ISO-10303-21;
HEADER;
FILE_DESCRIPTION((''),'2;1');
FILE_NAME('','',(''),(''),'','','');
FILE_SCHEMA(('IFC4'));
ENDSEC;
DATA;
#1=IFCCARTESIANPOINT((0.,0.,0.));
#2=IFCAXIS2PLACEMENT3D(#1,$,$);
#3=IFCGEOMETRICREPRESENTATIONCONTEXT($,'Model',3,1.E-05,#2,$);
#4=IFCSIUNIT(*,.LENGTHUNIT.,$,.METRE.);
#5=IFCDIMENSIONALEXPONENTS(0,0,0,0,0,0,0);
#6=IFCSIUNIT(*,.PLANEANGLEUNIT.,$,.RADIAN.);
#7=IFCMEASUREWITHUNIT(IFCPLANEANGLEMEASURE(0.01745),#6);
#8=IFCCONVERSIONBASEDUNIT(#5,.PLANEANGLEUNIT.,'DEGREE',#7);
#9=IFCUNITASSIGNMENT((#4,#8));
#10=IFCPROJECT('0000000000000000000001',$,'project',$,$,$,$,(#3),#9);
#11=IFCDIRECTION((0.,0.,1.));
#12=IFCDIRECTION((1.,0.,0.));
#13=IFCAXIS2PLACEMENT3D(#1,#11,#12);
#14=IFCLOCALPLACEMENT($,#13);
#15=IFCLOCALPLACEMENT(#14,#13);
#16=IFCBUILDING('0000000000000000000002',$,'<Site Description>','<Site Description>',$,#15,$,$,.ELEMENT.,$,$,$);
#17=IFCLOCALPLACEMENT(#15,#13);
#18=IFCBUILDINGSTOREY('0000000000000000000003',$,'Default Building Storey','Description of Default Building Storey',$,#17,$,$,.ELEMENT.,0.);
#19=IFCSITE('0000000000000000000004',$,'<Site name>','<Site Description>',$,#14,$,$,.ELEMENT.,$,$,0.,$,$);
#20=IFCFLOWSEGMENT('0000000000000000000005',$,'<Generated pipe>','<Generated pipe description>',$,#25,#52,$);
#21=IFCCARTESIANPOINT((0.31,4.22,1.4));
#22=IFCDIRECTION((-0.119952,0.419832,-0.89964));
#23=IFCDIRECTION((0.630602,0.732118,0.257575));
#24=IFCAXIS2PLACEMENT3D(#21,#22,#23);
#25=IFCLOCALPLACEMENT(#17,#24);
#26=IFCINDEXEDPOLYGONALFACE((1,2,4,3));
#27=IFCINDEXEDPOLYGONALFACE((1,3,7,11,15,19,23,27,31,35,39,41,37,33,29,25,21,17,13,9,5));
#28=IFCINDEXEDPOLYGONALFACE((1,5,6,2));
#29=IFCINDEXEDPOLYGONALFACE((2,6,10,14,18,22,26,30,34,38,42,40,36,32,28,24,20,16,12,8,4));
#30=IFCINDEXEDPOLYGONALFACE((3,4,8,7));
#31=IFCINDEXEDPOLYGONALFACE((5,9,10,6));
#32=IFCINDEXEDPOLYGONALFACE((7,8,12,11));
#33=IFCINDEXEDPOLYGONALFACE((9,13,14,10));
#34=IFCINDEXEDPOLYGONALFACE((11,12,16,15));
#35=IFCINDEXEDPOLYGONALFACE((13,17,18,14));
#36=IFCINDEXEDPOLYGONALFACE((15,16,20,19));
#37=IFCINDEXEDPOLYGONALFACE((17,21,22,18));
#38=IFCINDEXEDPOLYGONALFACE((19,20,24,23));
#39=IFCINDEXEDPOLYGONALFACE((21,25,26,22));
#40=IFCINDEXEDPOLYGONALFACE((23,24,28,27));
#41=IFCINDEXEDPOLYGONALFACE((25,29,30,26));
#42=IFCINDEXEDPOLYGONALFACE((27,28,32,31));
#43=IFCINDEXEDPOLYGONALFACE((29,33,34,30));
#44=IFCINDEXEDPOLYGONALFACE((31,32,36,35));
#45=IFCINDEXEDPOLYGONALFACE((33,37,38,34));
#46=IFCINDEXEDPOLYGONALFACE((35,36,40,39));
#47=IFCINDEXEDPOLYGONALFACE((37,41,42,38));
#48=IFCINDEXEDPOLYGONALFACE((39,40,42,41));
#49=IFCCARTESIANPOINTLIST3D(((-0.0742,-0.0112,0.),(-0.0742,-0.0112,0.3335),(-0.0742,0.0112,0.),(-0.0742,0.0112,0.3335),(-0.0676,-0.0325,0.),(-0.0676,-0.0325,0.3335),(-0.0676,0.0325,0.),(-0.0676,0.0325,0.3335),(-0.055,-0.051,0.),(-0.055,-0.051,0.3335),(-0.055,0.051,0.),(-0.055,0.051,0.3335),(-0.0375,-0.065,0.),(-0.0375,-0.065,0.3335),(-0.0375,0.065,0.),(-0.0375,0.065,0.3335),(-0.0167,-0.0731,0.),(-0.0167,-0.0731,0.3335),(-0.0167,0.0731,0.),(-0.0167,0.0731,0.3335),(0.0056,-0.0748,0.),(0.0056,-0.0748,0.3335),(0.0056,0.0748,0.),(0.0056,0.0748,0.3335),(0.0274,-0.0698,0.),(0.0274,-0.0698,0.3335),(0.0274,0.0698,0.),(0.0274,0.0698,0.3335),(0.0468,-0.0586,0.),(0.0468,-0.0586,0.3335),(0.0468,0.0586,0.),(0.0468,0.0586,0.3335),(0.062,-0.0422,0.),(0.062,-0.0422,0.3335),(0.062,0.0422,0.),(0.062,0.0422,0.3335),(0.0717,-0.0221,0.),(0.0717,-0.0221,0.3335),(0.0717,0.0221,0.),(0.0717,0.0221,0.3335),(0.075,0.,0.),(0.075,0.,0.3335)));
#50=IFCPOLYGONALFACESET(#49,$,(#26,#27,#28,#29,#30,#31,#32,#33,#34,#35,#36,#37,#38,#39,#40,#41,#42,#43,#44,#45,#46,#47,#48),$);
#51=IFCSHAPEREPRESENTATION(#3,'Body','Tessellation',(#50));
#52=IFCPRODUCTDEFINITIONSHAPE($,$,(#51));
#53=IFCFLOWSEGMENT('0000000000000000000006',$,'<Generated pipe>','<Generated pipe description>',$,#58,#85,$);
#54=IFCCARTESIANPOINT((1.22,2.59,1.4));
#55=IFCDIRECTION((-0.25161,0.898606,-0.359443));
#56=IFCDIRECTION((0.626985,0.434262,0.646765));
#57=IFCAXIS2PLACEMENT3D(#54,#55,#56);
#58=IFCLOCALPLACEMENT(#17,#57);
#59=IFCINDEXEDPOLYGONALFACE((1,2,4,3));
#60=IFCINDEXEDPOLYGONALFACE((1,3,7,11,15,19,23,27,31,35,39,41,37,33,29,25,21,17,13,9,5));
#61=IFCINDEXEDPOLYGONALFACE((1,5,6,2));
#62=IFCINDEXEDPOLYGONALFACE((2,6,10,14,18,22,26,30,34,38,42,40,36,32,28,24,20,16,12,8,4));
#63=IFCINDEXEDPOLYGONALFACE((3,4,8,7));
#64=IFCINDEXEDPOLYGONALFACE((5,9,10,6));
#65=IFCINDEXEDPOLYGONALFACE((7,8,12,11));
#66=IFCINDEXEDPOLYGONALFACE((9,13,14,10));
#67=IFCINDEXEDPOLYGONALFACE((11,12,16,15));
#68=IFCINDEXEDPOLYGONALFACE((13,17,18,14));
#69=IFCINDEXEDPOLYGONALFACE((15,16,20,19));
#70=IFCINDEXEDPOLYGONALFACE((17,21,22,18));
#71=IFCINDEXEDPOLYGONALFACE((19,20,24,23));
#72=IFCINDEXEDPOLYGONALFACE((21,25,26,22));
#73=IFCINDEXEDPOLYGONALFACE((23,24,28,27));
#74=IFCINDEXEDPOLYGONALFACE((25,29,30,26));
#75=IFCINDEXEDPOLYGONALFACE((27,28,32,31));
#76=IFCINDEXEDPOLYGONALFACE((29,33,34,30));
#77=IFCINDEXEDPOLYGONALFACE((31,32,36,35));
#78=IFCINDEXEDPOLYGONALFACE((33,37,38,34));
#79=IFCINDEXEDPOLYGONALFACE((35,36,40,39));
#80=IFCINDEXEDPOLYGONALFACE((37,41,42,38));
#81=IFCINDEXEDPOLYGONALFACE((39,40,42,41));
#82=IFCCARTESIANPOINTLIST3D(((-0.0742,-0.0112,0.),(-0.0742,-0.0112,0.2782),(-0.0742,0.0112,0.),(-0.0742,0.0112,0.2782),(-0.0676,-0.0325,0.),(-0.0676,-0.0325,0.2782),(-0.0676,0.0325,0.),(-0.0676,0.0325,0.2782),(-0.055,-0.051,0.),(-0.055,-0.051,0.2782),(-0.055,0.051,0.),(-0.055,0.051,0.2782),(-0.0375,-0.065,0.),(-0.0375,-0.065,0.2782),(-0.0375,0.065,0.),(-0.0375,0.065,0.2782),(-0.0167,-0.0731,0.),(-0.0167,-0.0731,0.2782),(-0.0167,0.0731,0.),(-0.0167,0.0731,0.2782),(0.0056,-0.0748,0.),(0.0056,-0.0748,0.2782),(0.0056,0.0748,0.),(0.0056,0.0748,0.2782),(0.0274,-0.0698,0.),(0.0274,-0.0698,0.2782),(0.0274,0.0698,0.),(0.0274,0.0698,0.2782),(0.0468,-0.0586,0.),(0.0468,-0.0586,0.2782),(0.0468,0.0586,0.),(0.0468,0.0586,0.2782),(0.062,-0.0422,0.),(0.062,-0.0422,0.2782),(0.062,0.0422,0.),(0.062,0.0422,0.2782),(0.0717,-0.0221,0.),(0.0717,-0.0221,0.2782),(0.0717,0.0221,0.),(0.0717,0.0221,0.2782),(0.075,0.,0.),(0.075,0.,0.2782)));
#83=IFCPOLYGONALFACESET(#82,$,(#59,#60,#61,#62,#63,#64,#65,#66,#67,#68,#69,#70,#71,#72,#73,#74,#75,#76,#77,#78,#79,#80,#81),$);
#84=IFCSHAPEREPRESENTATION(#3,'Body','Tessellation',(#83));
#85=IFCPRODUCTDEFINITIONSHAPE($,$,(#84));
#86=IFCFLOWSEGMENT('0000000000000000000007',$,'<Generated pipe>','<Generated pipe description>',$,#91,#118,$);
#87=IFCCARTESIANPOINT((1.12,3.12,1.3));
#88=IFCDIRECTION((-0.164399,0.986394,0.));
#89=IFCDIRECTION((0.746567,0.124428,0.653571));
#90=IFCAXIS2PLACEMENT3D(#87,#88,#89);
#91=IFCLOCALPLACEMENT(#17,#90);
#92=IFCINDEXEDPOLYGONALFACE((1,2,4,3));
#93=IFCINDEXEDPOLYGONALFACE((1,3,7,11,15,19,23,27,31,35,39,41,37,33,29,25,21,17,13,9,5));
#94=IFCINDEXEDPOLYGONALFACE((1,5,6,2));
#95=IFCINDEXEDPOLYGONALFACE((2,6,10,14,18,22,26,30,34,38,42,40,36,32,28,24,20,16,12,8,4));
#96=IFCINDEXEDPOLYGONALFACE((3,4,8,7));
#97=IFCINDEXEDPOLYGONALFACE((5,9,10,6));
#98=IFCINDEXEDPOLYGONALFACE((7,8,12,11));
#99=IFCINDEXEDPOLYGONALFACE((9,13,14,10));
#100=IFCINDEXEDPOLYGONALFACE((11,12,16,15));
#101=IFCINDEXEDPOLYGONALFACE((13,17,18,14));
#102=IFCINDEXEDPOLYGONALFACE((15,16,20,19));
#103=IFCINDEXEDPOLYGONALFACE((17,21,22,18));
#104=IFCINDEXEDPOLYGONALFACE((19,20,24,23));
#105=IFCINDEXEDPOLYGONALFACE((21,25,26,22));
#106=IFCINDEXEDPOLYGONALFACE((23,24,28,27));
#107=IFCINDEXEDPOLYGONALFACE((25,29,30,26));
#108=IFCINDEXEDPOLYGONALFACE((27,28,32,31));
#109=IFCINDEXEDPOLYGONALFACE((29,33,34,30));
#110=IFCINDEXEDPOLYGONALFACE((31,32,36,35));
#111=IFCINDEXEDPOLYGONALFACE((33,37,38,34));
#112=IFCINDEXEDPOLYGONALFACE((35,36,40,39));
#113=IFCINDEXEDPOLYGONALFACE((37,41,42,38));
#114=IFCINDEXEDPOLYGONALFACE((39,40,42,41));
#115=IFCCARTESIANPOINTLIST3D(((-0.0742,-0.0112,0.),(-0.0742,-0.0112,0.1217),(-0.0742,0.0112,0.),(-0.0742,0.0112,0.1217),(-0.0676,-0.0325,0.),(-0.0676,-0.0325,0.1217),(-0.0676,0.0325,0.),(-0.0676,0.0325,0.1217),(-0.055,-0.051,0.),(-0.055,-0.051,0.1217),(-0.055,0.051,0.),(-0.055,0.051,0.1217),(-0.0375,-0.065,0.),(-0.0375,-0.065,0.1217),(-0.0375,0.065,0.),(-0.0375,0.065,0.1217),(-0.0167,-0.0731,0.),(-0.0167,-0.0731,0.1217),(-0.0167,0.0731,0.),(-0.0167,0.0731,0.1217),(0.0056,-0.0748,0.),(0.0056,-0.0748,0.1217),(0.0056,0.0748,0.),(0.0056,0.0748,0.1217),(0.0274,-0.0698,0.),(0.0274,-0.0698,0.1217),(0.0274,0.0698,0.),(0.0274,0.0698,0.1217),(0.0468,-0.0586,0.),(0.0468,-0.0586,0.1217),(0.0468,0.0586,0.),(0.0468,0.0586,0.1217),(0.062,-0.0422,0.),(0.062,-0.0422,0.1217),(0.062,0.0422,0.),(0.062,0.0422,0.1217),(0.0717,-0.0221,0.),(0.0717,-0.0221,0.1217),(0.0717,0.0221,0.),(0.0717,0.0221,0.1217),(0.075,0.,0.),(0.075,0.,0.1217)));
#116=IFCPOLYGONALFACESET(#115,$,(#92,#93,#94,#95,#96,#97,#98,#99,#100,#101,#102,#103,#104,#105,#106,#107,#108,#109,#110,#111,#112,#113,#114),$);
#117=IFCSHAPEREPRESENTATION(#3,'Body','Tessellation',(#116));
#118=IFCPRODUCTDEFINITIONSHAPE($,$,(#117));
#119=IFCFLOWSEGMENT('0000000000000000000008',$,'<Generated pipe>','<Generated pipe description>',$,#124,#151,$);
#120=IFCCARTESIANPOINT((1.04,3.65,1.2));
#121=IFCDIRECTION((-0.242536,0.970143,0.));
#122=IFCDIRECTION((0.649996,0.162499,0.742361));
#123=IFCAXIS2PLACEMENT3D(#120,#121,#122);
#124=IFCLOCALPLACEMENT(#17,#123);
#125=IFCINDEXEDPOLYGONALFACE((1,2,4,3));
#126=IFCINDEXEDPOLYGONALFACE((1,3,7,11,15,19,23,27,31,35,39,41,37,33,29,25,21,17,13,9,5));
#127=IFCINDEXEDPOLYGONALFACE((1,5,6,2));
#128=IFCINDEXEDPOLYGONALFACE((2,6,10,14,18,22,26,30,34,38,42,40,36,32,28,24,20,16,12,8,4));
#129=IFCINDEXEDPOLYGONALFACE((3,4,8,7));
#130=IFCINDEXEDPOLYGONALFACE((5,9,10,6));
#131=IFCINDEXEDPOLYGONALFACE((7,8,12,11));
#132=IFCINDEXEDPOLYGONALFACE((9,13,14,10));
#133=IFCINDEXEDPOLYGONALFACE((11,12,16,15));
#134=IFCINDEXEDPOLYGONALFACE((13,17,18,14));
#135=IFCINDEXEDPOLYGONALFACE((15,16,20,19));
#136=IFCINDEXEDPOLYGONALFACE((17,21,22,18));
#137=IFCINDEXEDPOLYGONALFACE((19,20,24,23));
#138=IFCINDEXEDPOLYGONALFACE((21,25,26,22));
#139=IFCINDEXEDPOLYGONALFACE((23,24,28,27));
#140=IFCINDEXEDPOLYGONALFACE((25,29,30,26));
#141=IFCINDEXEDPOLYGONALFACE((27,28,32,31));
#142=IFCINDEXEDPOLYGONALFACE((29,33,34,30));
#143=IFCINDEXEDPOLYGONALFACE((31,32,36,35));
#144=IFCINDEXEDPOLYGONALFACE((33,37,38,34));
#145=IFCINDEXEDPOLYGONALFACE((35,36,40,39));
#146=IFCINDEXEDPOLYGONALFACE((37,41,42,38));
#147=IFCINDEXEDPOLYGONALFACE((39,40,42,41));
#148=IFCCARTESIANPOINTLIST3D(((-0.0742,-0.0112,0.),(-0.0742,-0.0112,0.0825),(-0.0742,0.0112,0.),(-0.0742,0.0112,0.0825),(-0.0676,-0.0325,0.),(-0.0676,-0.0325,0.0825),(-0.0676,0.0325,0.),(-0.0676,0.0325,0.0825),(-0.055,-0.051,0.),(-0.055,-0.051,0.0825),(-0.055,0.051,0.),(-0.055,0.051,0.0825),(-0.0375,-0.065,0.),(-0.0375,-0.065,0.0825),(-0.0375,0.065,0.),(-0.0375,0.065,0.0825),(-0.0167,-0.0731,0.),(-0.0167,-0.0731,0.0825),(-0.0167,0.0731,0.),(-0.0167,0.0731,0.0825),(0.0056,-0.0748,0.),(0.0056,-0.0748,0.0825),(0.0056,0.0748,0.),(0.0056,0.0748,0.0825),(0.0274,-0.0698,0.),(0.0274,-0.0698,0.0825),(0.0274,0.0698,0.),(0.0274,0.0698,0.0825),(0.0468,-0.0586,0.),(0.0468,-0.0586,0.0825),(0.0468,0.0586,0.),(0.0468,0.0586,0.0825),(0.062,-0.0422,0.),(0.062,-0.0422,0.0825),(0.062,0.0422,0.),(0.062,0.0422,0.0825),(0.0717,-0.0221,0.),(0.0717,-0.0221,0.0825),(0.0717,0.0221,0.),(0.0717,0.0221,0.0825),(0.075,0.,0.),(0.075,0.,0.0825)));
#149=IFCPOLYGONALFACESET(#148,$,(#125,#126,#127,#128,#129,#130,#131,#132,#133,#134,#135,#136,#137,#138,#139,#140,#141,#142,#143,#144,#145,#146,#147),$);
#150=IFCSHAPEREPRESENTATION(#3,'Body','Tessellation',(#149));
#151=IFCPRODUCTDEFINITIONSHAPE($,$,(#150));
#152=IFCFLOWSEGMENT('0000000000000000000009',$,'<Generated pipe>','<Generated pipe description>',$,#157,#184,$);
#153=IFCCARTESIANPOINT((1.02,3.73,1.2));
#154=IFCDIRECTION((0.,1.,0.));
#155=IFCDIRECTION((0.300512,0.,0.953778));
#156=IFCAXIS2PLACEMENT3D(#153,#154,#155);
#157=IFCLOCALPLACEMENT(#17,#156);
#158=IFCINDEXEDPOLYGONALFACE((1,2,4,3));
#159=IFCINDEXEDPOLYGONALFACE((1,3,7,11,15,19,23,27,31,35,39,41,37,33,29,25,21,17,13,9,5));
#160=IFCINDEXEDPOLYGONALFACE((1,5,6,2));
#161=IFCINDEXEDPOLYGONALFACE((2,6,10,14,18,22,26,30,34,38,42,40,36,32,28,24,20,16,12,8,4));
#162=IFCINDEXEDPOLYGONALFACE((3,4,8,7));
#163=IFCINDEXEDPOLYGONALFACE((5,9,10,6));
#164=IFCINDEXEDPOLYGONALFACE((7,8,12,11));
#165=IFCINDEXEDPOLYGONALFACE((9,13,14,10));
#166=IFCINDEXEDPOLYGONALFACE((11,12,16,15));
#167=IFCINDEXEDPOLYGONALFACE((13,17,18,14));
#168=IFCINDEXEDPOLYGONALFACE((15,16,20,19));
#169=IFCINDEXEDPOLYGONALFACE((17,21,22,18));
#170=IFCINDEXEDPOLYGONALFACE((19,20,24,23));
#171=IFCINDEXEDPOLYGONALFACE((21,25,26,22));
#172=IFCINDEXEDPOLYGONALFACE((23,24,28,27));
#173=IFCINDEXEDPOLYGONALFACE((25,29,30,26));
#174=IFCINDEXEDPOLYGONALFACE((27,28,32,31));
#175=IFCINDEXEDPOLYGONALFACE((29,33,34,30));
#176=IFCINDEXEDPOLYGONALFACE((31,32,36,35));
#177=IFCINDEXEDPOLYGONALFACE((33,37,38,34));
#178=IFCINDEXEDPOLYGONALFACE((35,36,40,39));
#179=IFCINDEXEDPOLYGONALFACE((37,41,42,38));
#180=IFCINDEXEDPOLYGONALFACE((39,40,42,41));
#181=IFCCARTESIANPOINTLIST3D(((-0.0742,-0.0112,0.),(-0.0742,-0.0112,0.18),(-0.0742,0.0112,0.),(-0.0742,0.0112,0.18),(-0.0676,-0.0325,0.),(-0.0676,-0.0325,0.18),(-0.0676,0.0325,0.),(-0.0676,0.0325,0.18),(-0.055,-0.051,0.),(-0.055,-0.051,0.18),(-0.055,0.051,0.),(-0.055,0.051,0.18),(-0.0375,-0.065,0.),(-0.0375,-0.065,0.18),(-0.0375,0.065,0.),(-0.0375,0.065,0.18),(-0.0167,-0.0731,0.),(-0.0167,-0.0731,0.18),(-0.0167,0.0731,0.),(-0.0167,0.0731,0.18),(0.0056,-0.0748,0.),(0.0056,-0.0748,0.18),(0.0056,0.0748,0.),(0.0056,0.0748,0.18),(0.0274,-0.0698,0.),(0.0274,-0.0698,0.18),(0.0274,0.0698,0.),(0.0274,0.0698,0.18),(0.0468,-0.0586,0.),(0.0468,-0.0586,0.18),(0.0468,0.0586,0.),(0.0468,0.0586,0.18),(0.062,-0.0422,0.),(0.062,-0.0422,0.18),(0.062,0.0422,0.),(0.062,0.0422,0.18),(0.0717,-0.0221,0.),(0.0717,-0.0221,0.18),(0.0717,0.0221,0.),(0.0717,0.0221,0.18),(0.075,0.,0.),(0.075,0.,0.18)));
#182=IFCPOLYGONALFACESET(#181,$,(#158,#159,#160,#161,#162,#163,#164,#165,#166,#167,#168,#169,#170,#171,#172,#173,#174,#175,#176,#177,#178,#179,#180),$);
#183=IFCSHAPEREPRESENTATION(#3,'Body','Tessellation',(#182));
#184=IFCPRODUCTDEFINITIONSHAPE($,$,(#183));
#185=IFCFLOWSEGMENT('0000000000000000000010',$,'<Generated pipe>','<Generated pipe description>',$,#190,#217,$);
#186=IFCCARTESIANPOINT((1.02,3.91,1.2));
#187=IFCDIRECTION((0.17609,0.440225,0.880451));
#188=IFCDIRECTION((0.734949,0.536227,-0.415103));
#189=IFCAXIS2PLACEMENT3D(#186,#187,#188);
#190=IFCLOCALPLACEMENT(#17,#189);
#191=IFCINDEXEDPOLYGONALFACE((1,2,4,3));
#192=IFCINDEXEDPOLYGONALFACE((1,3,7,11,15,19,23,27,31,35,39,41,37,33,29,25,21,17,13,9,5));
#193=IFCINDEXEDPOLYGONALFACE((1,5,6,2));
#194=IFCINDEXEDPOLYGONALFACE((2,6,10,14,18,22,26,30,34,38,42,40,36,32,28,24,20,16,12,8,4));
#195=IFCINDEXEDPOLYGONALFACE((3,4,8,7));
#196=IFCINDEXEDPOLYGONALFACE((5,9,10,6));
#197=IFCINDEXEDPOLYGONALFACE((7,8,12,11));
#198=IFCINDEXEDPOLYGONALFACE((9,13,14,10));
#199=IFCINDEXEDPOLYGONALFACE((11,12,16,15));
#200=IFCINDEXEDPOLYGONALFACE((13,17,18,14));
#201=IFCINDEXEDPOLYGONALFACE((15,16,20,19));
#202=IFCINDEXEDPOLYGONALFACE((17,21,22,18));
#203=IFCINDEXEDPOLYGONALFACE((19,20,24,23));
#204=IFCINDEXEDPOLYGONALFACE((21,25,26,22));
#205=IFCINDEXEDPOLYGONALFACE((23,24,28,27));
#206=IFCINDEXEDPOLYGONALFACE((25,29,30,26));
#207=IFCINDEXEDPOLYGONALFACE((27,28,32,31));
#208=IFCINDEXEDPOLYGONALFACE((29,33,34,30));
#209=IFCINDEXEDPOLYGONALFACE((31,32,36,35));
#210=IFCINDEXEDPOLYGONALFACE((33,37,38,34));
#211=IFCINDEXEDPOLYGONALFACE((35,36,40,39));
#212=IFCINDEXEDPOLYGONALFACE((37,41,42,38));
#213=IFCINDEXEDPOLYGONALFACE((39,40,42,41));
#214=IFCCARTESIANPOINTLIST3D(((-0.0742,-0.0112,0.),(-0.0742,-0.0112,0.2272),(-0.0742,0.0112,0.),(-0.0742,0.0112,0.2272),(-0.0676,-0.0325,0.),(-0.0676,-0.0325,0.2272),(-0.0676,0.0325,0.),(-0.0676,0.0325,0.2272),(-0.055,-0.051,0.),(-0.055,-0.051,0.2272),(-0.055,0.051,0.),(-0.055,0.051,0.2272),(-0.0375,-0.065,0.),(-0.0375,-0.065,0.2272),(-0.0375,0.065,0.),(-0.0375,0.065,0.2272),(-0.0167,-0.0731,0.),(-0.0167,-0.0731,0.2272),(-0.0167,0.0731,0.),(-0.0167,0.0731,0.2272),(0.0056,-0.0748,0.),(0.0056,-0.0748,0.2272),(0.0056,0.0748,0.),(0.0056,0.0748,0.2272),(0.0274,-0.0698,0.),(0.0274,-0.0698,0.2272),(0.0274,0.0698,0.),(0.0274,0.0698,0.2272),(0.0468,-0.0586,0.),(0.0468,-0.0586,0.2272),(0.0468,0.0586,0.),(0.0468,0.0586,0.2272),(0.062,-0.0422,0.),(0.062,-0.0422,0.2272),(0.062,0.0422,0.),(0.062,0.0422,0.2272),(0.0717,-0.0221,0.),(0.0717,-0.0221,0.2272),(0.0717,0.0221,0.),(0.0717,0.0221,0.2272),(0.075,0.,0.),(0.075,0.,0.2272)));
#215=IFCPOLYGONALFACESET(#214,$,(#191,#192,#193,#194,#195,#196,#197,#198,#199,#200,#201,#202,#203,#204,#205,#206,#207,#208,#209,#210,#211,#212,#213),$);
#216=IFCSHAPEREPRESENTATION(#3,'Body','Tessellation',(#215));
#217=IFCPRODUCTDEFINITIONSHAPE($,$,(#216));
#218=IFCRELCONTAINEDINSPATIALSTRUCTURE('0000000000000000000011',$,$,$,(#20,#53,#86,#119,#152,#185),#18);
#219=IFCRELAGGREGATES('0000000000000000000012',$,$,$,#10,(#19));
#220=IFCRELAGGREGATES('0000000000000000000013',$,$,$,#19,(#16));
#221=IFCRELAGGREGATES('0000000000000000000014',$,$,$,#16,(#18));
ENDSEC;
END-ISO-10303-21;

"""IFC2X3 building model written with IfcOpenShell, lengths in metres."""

from ifc_helpers import new_model, entity, si_unit, converted_unit, frame, origin, origin_with_axes, origin_2d_with_axis, place, context, project, spatial, circle, extrude, element, save


model = new_model("IFC2X3")

# Units and contexts
model_context = context("Model", 3, precision=1e-05, world=origin())
ifc_project = project(units=[si_unit("LENGTHUNIT", "METRE"), converted_unit("PLANEANGLEUNIT", "DEGREE", entity("IfcPlaneAngleMeasure", 0.01745), si_unit("PLANEANGLEUNIT", "RADIAN"), dimensions=[0, 0, 0, 0, 0, 0, 0])], contexts=[model_context])

# Site, building, storey
site_placement = place(None, origin_with_axes())
site = spatial("IfcSite", under=ifc_project, at=site_placement, Name="<Site name>", Description="<Site Description>", CompositionType="ELEMENT", RefElevation=0.0)
building_placement = place(site_placement, origin_with_axes())
building = spatial("IfcBuilding", under=site, at=building_placement, Name="<Site Description>", Description="<Site Description>", CompositionType="ELEMENT")
storey_placement = place(building_placement, origin_with_axes())
storey = spatial("IfcBuildingStorey", under=building, at=storey_placement, Name="Default Building Storey", Description="Description of Default Building Storey", CompositionType="ELEMENT", Elevation=0.0)

# Flow segments
flow_segment_1_placement = place(storey_placement, frame((0.31, 4.22, 1.4), z_axis=(-0.119952, 0.419832, -0.89964), x_axis=(0.630602, 0.732118, 0.257575)))
element("IfcFlowSegment", 1, at=flow_segment_1_placement, inside=storey, Name="<Generated pipe>", Description="<Generated pipe description>", context=model_context, shape_type="SweptSolid", body=[
    extrude(circle(Radius=0.075, at=origin_2d_with_axis()), origin_with_axes(), (0.0, 0.0, 1.0), 0.3335),
])
flow_segment_2_placement = place(storey_placement, frame((1.22, 2.59, 1.4), z_axis=(-0.25161, 0.898606, -0.359443), x_axis=(0.626985, 0.434262, 0.646765)))
element("IfcFlowSegment", 2, at=flow_segment_2_placement, inside=storey, Name="<Generated pipe>", Description="<Generated pipe description>", context=model_context, shape_type="SweptSolid", body=[
    extrude(circle(Radius=0.075, at=origin_2d_with_axis()), origin_with_axes(), (0.0, 0.0, 1.0), 0.2782),
])
flow_segment_3_placement = place(storey_placement, frame((1.12, 3.12, 1.3), z_axis=(-0.164399, 0.986394, 0.0), x_axis=(0.746567, 0.124428, 0.653571)))
element("IfcFlowSegment", 3, at=flow_segment_3_placement, inside=storey, Name="<Generated pipe>", Description="<Generated pipe description>", context=model_context, shape_type="SweptSolid", body=[
    extrude(circle(Radius=0.075, at=origin_2d_with_axis()), origin_with_axes(), (0.0, 0.0, 1.0), 0.1217),
])
flow_segment_4_placement = place(storey_placement, frame((1.04, 3.65, 1.2), z_axis=(-0.242536, 0.970143, 0.0), x_axis=(0.649996, 0.162499, 0.742361)))
element("IfcFlowSegment", 4, at=flow_segment_4_placement, inside=storey, Name="<Generated pipe>", Description="<Generated pipe description>", context=model_context, shape_type="SweptSolid", body=[
    extrude(circle(Radius=0.075, at=origin_2d_with_axis()), origin_with_axes(), (0.0, 0.0, 1.0), 0.0825),
])
flow_segment_5_placement = place(storey_placement, frame((1.02, 3.73, 1.2), z_axis=(0.0, 1.0, 0.0), x_axis=(0.300512, 0.0, 0.953778)))
element("IfcFlowSegment", 5, at=flow_segment_5_placement, inside=storey, Name="<Generated pipe>", Description="<Generated pipe description>", context=model_context, shape_type="SweptSolid", body=[
    extrude(circle(Radius=0.075, at=origin_2d_with_axis()), origin_with_axes(), (0.0, 0.0, 1.0), 0.18),
])
flow_segment_6_placement = place(storey_placement, frame((1.02, 3.91, 1.2), z_axis=(0.17609, 0.440225, 0.880451), x_axis=(0.734949, 0.536227, -0.415103)))
element("IfcFlowSegment", 6, at=flow_segment_6_placement, inside=storey, Name="<Generated pipe>", Description="<Generated pipe description>", context=model_context, shape_type="SweptSolid", body=[
    extrude(circle(Radius=0.075, at=origin_2d_with_axis()), origin_with_axes(), (0.0, 0.0, 1.0), 0.2272),
])

save(model, "model.ifc")
